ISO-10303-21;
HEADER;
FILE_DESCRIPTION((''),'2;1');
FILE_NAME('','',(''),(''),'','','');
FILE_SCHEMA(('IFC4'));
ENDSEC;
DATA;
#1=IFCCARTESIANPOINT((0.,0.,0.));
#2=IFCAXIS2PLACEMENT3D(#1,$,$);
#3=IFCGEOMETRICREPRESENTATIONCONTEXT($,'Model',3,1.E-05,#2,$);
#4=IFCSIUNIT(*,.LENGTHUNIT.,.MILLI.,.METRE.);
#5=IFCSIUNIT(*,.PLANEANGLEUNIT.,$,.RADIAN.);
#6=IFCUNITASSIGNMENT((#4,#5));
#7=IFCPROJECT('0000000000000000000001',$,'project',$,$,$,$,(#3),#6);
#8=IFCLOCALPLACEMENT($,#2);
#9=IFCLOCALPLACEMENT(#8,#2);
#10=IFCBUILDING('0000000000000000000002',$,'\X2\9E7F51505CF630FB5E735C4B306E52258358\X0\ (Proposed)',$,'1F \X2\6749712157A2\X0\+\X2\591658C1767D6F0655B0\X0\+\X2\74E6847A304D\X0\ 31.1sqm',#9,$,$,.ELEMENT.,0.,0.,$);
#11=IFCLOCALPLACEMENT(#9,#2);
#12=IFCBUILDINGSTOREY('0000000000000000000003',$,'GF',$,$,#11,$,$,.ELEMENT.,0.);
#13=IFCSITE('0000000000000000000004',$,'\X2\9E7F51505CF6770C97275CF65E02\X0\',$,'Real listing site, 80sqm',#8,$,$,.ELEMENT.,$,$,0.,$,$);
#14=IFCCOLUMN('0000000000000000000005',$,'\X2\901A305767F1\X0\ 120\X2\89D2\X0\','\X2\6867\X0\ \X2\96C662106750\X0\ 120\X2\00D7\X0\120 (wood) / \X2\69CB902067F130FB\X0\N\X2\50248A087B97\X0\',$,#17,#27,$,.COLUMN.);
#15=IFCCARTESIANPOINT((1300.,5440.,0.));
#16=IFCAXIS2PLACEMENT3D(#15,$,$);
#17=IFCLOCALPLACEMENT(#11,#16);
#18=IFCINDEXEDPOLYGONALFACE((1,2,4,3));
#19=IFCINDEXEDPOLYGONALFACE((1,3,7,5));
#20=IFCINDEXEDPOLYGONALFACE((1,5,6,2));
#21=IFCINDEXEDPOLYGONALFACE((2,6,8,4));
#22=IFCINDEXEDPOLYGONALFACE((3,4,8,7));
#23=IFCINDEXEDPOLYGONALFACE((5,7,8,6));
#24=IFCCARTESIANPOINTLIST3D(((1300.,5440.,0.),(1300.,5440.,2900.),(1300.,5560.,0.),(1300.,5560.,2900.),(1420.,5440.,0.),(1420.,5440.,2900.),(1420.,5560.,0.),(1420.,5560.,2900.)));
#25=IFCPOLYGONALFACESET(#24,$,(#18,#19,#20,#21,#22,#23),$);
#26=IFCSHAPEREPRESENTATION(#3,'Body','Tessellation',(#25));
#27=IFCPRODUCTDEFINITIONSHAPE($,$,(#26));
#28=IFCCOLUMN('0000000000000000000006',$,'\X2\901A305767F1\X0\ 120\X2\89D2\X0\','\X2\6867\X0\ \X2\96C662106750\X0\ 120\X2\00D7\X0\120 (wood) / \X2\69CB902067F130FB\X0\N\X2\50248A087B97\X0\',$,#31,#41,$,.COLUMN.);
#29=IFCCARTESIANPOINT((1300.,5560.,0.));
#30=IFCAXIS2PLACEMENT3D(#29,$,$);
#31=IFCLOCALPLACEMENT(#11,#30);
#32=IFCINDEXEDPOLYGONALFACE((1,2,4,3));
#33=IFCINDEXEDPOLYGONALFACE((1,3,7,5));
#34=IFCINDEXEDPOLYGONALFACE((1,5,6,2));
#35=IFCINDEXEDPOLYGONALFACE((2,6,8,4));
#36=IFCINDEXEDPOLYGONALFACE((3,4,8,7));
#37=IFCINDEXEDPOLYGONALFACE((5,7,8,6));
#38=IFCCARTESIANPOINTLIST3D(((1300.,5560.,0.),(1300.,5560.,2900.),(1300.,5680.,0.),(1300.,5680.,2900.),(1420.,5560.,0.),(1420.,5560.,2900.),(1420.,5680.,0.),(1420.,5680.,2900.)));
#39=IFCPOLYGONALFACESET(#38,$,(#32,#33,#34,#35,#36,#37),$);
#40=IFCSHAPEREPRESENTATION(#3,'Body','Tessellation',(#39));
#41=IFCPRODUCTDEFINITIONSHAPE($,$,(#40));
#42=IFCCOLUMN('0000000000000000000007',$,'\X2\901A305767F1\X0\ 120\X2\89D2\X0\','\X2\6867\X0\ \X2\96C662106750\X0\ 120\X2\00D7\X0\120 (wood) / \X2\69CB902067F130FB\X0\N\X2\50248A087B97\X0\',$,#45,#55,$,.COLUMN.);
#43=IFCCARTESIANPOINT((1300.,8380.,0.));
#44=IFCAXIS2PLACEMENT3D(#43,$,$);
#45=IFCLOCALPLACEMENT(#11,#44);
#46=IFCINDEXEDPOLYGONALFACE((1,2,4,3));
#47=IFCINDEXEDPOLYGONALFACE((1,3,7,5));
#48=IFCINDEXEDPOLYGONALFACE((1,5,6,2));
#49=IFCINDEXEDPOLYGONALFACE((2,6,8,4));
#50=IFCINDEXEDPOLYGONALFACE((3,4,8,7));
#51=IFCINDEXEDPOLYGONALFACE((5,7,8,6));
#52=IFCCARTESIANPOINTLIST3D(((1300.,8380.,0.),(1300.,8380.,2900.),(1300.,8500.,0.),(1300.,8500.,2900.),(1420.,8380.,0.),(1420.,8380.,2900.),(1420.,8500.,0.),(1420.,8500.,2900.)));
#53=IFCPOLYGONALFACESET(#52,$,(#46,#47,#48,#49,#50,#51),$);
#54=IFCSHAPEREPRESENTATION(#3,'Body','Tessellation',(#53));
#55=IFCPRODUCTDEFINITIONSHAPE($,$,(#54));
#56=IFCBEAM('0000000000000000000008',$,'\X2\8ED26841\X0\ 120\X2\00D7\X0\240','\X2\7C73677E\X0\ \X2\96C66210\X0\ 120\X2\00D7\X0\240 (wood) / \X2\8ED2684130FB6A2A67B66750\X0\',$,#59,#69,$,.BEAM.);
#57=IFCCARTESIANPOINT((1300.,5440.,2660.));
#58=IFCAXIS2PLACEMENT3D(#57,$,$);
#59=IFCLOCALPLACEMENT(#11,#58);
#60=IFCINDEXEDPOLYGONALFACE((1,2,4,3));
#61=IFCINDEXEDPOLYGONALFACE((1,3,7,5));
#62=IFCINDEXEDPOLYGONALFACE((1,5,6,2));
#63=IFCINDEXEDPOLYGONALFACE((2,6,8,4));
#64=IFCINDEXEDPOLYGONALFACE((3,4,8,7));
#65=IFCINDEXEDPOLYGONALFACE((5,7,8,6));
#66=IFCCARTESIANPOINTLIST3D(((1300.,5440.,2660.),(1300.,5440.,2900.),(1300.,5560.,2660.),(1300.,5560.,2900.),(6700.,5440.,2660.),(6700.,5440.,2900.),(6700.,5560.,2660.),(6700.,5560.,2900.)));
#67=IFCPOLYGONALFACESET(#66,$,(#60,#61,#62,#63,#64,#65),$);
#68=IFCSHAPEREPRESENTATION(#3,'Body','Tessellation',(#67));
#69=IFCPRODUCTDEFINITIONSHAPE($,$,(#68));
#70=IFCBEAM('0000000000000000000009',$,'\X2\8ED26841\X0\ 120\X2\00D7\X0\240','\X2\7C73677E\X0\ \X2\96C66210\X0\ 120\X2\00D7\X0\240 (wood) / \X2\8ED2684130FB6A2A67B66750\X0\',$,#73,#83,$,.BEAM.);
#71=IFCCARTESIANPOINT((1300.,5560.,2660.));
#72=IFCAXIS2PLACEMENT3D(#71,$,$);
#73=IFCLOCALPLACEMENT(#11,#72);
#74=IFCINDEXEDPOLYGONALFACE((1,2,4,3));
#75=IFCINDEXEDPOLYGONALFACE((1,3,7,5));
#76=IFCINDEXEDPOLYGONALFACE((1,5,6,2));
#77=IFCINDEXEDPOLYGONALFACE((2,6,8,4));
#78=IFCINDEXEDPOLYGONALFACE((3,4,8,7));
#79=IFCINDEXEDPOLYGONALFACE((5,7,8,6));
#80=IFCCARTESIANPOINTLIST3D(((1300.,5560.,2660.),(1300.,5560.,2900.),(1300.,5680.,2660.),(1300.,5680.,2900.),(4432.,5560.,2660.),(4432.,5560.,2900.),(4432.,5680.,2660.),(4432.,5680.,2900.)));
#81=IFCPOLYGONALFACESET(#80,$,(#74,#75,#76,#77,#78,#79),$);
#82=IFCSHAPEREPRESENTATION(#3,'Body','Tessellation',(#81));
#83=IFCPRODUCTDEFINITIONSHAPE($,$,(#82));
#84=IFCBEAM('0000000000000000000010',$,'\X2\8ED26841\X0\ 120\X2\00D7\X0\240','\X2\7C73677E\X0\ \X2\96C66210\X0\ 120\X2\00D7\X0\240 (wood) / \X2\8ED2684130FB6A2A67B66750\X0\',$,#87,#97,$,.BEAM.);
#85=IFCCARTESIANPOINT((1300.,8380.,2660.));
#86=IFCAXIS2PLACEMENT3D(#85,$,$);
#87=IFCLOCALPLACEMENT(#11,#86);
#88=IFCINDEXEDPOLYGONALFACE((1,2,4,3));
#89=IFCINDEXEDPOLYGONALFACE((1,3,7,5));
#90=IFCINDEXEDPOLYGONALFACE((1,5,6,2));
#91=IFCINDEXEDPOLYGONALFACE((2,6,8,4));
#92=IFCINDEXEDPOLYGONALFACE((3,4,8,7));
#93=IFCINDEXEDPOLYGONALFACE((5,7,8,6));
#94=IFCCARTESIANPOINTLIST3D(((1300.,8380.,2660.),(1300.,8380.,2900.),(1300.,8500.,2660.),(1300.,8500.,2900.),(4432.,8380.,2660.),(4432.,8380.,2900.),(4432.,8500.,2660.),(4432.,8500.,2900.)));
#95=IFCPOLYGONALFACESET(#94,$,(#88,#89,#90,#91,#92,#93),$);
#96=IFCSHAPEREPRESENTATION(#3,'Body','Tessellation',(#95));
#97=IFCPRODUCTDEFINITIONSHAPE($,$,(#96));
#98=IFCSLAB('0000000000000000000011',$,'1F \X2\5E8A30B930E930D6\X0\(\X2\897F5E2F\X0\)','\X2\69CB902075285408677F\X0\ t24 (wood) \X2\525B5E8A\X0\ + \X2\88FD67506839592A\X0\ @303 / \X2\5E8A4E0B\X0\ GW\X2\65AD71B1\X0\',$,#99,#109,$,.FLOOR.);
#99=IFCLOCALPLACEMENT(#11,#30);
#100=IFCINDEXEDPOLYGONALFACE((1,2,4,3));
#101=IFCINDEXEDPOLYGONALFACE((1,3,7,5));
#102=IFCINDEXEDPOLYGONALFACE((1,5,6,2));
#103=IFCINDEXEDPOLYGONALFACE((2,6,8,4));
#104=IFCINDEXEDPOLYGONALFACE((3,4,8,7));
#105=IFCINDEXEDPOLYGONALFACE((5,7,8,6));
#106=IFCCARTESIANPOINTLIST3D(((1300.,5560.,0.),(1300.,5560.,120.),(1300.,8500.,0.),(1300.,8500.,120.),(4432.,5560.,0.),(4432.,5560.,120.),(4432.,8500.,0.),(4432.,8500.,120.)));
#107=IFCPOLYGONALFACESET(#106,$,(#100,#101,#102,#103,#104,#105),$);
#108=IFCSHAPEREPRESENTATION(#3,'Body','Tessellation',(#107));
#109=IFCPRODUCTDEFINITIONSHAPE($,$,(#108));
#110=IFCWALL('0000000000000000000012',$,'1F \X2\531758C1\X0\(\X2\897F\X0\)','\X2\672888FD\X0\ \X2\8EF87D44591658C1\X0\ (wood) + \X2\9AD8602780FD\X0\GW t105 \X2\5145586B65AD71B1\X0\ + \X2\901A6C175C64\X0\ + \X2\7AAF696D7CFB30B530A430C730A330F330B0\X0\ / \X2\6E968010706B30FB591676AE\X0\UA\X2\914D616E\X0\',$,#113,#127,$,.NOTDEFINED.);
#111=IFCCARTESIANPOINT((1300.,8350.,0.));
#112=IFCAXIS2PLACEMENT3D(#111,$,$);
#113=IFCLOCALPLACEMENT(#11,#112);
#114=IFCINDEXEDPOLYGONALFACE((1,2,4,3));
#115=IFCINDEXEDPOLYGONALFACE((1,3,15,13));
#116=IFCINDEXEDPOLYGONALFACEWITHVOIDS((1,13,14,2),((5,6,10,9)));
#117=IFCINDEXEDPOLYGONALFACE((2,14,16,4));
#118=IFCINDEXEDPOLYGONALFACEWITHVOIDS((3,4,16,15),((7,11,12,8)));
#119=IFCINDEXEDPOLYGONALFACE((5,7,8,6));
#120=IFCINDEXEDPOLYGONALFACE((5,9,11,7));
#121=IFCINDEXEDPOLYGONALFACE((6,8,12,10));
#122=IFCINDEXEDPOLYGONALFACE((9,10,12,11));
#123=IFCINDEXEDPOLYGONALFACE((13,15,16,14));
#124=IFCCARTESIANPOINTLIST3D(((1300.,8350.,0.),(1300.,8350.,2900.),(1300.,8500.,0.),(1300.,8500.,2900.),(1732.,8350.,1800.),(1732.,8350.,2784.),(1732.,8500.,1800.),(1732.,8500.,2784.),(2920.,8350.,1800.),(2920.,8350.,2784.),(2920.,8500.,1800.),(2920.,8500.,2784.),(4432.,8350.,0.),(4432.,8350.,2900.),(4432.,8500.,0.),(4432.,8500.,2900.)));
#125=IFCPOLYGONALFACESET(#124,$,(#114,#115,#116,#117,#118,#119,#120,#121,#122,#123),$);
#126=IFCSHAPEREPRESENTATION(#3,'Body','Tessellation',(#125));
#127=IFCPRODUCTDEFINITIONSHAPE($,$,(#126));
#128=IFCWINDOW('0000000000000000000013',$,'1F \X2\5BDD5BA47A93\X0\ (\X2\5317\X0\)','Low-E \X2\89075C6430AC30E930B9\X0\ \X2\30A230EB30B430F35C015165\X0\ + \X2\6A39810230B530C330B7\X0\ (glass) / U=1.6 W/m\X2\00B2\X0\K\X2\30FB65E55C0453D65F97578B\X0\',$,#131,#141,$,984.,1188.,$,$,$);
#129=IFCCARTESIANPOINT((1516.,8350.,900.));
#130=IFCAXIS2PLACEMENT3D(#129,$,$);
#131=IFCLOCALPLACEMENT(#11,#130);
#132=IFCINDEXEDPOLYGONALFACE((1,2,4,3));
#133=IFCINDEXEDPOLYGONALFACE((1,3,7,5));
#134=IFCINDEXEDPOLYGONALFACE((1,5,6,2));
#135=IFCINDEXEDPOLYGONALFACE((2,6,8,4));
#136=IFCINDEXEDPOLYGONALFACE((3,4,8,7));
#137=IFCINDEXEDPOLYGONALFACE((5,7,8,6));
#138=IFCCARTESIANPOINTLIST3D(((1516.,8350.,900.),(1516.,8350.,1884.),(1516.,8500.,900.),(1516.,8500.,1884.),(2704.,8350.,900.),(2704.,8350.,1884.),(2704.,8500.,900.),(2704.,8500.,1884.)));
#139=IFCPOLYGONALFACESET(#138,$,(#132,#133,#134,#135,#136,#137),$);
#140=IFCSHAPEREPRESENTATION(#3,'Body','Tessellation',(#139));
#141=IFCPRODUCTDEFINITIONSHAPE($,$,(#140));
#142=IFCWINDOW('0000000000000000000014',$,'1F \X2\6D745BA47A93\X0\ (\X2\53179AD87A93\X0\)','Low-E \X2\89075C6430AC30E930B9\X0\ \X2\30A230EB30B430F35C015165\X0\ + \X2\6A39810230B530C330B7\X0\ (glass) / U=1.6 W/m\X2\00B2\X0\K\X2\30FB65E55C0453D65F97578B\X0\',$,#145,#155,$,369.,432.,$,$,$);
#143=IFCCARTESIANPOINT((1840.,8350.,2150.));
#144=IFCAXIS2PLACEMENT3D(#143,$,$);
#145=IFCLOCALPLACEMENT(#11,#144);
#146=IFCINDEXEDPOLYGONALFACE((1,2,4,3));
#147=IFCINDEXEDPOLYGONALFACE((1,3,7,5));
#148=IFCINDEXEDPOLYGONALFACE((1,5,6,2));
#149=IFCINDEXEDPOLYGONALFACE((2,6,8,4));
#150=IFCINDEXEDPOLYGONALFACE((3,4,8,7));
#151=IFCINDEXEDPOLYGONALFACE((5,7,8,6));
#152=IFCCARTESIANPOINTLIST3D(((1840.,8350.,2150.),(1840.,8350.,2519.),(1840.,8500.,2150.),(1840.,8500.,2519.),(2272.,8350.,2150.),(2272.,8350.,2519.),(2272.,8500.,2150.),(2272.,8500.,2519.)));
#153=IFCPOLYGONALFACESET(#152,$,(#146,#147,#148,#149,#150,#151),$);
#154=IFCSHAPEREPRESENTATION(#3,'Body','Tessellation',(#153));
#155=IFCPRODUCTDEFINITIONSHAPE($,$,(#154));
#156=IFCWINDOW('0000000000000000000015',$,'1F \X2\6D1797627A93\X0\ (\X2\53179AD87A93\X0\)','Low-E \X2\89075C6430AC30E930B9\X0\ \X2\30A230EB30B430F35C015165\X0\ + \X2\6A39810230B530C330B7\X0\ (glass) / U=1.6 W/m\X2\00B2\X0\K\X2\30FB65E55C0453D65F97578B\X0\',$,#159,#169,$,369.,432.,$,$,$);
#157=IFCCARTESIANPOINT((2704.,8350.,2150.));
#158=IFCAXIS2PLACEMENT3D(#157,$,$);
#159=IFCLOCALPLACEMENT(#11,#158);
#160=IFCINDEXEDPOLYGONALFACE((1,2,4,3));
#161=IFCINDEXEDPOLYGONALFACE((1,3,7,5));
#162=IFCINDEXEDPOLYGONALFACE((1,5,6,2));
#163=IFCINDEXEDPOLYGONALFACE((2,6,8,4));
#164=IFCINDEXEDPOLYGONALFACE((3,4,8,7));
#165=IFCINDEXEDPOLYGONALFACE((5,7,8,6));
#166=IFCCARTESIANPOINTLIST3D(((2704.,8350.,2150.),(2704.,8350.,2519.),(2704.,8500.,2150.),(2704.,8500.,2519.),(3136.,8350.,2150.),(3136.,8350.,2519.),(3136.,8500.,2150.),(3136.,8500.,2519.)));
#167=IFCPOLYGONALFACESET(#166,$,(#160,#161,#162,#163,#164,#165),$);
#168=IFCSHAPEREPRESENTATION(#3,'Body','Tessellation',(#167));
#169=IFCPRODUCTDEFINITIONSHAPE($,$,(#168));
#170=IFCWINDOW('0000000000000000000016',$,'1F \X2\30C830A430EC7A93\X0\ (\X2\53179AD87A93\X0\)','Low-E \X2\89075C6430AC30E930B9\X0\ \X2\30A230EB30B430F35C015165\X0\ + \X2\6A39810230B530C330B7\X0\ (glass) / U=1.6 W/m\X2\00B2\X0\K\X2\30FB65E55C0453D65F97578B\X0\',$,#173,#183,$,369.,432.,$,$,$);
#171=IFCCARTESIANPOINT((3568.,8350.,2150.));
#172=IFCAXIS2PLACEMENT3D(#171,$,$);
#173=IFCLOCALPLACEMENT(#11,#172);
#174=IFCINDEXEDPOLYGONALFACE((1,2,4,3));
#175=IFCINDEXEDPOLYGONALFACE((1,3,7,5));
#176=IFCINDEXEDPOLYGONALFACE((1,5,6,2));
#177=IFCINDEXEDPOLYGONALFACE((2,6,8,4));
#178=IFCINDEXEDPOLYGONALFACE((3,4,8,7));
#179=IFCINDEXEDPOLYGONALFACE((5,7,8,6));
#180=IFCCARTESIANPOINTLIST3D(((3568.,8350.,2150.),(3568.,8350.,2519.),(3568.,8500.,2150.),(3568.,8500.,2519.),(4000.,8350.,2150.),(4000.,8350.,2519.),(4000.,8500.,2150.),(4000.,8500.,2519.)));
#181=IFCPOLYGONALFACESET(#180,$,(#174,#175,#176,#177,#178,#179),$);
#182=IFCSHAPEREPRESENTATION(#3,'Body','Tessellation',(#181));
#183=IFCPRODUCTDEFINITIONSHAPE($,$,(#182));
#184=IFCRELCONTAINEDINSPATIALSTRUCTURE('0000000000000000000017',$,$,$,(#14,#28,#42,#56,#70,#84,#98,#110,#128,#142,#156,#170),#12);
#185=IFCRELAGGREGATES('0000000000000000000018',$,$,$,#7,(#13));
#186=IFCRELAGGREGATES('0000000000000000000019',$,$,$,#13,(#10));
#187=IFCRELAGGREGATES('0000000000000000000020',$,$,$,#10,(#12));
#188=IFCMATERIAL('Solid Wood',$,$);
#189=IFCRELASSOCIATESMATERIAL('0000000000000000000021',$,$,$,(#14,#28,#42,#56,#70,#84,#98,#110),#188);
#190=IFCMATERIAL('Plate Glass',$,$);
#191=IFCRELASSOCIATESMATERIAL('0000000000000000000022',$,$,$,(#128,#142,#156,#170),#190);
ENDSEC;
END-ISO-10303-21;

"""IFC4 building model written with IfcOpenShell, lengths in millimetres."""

from ifc_helpers import new_model, si_unit, frame, frame_2d, origin, place, context, project, spatial, rectangle, extrude, material, element, fill, save


model = new_model("IFC4")

# Units and contexts
model_context = context("Model", 3, precision=1e-05, world=origin())
ifc_project = project(units=[si_unit("LENGTHUNIT", "METRE", prefix="MILLI"), si_unit("PLANEANGLEUNIT", "RADIAN")], contexts=[model_context])

# Site, building, storey
site_placement = place(None, origin())
site = spatial("IfcSite", under=ifc_project, at=site_placement, Name="鹿児島県霧島市", ObjectType="Real listing site, 80sqm", CompositionType="ELEMENT", RefElevation=0.0)
building_placement = place(site_placement, origin())
building = spatial("IfcBuilding", under=site, at=building_placement, Name="鹿児島・平屋の別荘 (Proposed)", ObjectType="1F 杉無垢+外壁白漆喰+瓦葺き 31.1sqm", CompositionType="ELEMENT", ElevationOfRefHeight=0.0, ElevationOfTerrain=0.0)
storey_placement = place(building_placement, origin())
storey = spatial("IfcBuildingStorey", under=building, at=storey_placement, Name="GF", CompositionType="ELEMENT", Elevation=0.0)

# Columns
ifc_material_1 = material(Name="Solid Wood")
column_1_placement = place(storey_placement, frame((1300.0, 5440.0, 0.0)))
element("IfcColumn", 1, at=column_1_placement, inside=storey, material=ifc_material_1, Name="通し柱 120角", Description="桧 集成材 120×120 (wood) / 構造柱・N値計算", PredefinedType="COLUMN", context=model_context, shape_type="SweptSolid", body=[
    extrude(rectangle(XDim=120.0, YDim=120.0, at=frame_2d((60.0, 60.0))), frame((1300.0, 5440.0, 0.0)), (0.0, 0.0, 1.0), 2900.0),
])
column_2_placement = place(storey_placement, frame((1300.0, 5560.0, 0.0)))
element("IfcColumn", 2, at=column_2_placement, inside=storey, material=ifc_material_1, Name="通し柱 120角", Description="桧 集成材 120×120 (wood) / 構造柱・N値計算", PredefinedType="COLUMN", context=model_context, shape_type="SweptSolid", body=[
    extrude(rectangle(XDim=120.0, YDim=120.0, at=frame_2d((60.0, 60.0))), frame((1300.0, 5560.0, 0.0)), (0.0, 0.0, 1.0), 2900.0),
])
column_3_placement = place(storey_placement, frame((1300.0, 8380.0, 0.0)))
element("IfcColumn", 3, at=column_3_placement, inside=storey, material=ifc_material_1, Name="通し柱 120角", Description="桧 集成材 120×120 (wood) / 構造柱・N値計算", PredefinedType="COLUMN", context=model_context, shape_type="SweptSolid", body=[
    extrude(rectangle(XDim=120.0, YDim=120.0, at=frame_2d((60.0, 60.0))), frame((1300.0, 8380.0, 0.0)), (0.0, 0.0, 1.0), 2900.0),
])

# Beams
beam_1_placement = place(storey_placement, frame((1300.0, 5440.0, 2660.0)))
element("IfcBeam", 4, at=beam_1_placement, inside=storey, material=ifc_material_1, Name="軒桁 120×240", Description="米松 集成 120×240 (wood) / 軒桁・横架材", PredefinedType="BEAM", context=model_context, shape_type="SweptSolid", body=[
    extrude(rectangle(XDim=5400.0, YDim=120.0, at=frame_2d((2700.0, 60.0))), frame((1300.0, 5440.0, 2660.0)), (0.0, 0.0, 1.0), 240.0),
])
beam_2_placement = place(storey_placement, frame((1300.0, 5560.0, 2660.0)))
element("IfcBeam", 5, at=beam_2_placement, inside=storey, material=ifc_material_1, Name="軒桁 120×240", Description="米松 集成 120×240 (wood) / 軒桁・横架材", PredefinedType="BEAM", context=model_context, shape_type="SweptSolid", body=[
    extrude(rectangle(XDim=3132.0, YDim=120.0, at=frame_2d((1566.0, 60.0))), frame((1300.0, 5560.0, 2660.0)), (0.0, 0.0, 1.0), 240.0),
])
beam_3_placement = place(storey_placement, frame((1300.0, 8380.0, 2660.0)))
element("IfcBeam", 6, at=beam_3_placement, inside=storey, material=ifc_material_1, Name="軒桁 120×240", Description="米松 集成 120×240 (wood) / 軒桁・横架材", PredefinedType="BEAM", context=model_context, shape_type="SweptSolid", body=[
    extrude(rectangle(XDim=3132.0, YDim=120.0, at=frame_2d((1566.0, 60.0))), frame((1300.0, 8380.0, 2660.0)), (0.0, 0.0, 1.0), 240.0),
])

# Slab
slab_placement = place(storey_placement, frame((1300.0, 5560.0, 0.0)))
element("IfcSlab", 7, at=slab_placement, inside=storey, material=ifc_material_1, Name="1F 床スラブ(西帯)", Description="構造用合板 t24 (wood) 剛床 + 製材根太 @303 / 床下 GW断熱", PredefinedType="FLOOR", context=model_context, shape_type="SweptSolid", body=[
    extrude(rectangle(XDim=3132.0, YDim=2940.0, at=frame_2d((1566.0, 1470.0))), frame((1300.0, 5560.0, 0.0)), (0.0, 0.0, 1.0), 120.0),
])

# Wall, openings, windows
wall_1_placement = place(storey_placement, frame((1300.0, 8350.0, 0.0)))
wall_1 = element("IfcWall", 8, at=wall_1_placement, inside=storey, material=ifc_material_1, Name="1F 北壁(西)", Description="木製 軸組外壁 (wood) + 高性能GW t105 充填断熱 + 通気層 + 窯業系サイディング / 準耐火・外皮UA配慮", PredefinedType="NOTDEFINED", context=model_context, shape_type="SweptSolid", body=[
    extrude(rectangle(XDim=3132.0, YDim=150.0, at=frame_2d((1566.0, 75.0))), frame((1300.0, 8350.0, 0.0)), (0.0, 0.0, 1.0), 2900.0),
])
opening_1_placement = place(storey_placement, frame((1516.0, 8350.0, 900.0)))
opening_1 = element("IfcOpeningElement", 9, at=opening_1_placement, cuts=wall_1, PredefinedType="NOTDEFINED", context=model_context, shape_type="SweptSolid", body=[
    extrude(rectangle(XDim=1188.0, YDim=150.0, at=frame_2d((594.0, 75.0))), frame((1516.0, 8350.0, 900.0)), (0.0, 0.0, 1.0), 984.0),
])
opening_2_placement = place(storey_placement, frame((1840.0, 8350.0, 2150.0)))
opening_2 = element("IfcOpeningElement", 10, at=opening_2_placement, cuts=wall_1, PredefinedType="NOTDEFINED", context=model_context, shape_type="SweptSolid", body=[
    extrude(rectangle(XDim=432.0, YDim=150.0, at=frame_2d((216.0, 75.0))), frame((1840.0, 8350.0, 2150.0)), (0.0, 0.0, 1.0), 369.0),
])
opening_3_placement = place(storey_placement, frame((2704.0, 8350.0, 2150.0)))
opening_3 = element("IfcOpeningElement", 11, at=opening_3_placement, cuts=wall_1, PredefinedType="NOTDEFINED", context=model_context, shape_type="SweptSolid", body=[
    extrude(rectangle(XDim=432.0, YDim=150.0, at=frame_2d((216.0, 75.0))), frame((2704.0, 8350.0, 2150.0)), (0.0, 0.0, 1.0), 369.0),
])
opening_4_placement = place(storey_placement, frame((3568.0, 8350.0, 2150.0)))
opening_4 = element("IfcOpeningElement", 12, at=opening_4_placement, cuts=wall_1, PredefinedType="NOTDEFINED", context=model_context, shape_type="SweptSolid", body=[
    extrude(rectangle(XDim=432.0, YDim=150.0, at=frame_2d((216.0, 75.0))), frame((3568.0, 8350.0, 2150.0)), (0.0, 0.0, 1.0), 369.0),
])
ifc_material_2 = material(Name="Plate Glass")
window_1_placement = place(storey_placement, frame((1516.0, 8350.0, 900.0)))
window_1 = element("IfcWindow", 13, at=window_1_placement, inside=storey, material=ifc_material_2, Name="1F 寝室窓 (北)", Description="Low-E 複層ガラス アルゴン封入 + 樹脂サッシ (glass) / U=1.6 W/m²K・日射取得型", OverallHeight=984.0, OverallWidth=1188.0, context=model_context, shape_type="SweptSolid", body=[
    extrude(rectangle(XDim=1188.0, YDim=150.0, at=frame_2d((594.0, 75.0))), frame((1516.0, 8350.0, 900.0)), (0.0, 0.0, 1.0), 984.0),
])
fill(opening_1, window_1)
window_2_placement = place(storey_placement, frame((1840.0, 8350.0, 2150.0)))
window_2 = element("IfcWindow", 14, at=window_2_placement, inside=storey, material=ifc_material_2, Name="1F 浴室窓 (北高窓)", Description="Low-E 複層ガラス アルゴン封入 + 樹脂サッシ (glass) / U=1.6 W/m²K・日射取得型", OverallHeight=369.0, OverallWidth=432.0, context=model_context, shape_type="SweptSolid", body=[
    extrude(rectangle(XDim=432.0, YDim=150.0, at=frame_2d((216.0, 75.0))), frame((1840.0, 8350.0, 2150.0)), (0.0, 0.0, 1.0), 369.0),
])
fill(opening_2, window_2)
window_3_placement = place(storey_placement, frame((2704.0, 8350.0, 2150.0)))
window_3 = element("IfcWindow", 15, at=window_3_placement, inside=storey, material=ifc_material_2, Name="1F 洗面窓 (北高窓)", Description="Low-E 複層ガラス アルゴン封入 + 樹脂サッシ (glass) / U=1.6 W/m²K・日射取得型", OverallHeight=369.0, OverallWidth=432.0, context=model_context, shape_type="SweptSolid", body=[
    extrude(rectangle(XDim=432.0, YDim=150.0, at=frame_2d((216.0, 75.0))), frame((2704.0, 8350.0, 2150.0)), (0.0, 0.0, 1.0), 369.0),
])
fill(opening_3, window_3)
window_4_placement = place(storey_placement, frame((3568.0, 8350.0, 2150.0)))
window_4 = element("IfcWindow", 16, at=window_4_placement, inside=storey, material=ifc_material_2, Name="1F トイレ窓 (北高窓)", Description="Low-E 複層ガラス アルゴン封入 + 樹脂サッシ (glass) / U=1.6 W/m²K・日射取得型", OverallHeight=369.0, OverallWidth=432.0, context=model_context, shape_type="SweptSolid", body=[
    extrude(rectangle(XDim=432.0, YDim=150.0, at=frame_2d((216.0, 75.0))), frame((3568.0, 8350.0, 2150.0)), (0.0, 0.0, 1.0), 369.0),
])
fill(opening_4, window_4)

save(model, "model.ifc")
